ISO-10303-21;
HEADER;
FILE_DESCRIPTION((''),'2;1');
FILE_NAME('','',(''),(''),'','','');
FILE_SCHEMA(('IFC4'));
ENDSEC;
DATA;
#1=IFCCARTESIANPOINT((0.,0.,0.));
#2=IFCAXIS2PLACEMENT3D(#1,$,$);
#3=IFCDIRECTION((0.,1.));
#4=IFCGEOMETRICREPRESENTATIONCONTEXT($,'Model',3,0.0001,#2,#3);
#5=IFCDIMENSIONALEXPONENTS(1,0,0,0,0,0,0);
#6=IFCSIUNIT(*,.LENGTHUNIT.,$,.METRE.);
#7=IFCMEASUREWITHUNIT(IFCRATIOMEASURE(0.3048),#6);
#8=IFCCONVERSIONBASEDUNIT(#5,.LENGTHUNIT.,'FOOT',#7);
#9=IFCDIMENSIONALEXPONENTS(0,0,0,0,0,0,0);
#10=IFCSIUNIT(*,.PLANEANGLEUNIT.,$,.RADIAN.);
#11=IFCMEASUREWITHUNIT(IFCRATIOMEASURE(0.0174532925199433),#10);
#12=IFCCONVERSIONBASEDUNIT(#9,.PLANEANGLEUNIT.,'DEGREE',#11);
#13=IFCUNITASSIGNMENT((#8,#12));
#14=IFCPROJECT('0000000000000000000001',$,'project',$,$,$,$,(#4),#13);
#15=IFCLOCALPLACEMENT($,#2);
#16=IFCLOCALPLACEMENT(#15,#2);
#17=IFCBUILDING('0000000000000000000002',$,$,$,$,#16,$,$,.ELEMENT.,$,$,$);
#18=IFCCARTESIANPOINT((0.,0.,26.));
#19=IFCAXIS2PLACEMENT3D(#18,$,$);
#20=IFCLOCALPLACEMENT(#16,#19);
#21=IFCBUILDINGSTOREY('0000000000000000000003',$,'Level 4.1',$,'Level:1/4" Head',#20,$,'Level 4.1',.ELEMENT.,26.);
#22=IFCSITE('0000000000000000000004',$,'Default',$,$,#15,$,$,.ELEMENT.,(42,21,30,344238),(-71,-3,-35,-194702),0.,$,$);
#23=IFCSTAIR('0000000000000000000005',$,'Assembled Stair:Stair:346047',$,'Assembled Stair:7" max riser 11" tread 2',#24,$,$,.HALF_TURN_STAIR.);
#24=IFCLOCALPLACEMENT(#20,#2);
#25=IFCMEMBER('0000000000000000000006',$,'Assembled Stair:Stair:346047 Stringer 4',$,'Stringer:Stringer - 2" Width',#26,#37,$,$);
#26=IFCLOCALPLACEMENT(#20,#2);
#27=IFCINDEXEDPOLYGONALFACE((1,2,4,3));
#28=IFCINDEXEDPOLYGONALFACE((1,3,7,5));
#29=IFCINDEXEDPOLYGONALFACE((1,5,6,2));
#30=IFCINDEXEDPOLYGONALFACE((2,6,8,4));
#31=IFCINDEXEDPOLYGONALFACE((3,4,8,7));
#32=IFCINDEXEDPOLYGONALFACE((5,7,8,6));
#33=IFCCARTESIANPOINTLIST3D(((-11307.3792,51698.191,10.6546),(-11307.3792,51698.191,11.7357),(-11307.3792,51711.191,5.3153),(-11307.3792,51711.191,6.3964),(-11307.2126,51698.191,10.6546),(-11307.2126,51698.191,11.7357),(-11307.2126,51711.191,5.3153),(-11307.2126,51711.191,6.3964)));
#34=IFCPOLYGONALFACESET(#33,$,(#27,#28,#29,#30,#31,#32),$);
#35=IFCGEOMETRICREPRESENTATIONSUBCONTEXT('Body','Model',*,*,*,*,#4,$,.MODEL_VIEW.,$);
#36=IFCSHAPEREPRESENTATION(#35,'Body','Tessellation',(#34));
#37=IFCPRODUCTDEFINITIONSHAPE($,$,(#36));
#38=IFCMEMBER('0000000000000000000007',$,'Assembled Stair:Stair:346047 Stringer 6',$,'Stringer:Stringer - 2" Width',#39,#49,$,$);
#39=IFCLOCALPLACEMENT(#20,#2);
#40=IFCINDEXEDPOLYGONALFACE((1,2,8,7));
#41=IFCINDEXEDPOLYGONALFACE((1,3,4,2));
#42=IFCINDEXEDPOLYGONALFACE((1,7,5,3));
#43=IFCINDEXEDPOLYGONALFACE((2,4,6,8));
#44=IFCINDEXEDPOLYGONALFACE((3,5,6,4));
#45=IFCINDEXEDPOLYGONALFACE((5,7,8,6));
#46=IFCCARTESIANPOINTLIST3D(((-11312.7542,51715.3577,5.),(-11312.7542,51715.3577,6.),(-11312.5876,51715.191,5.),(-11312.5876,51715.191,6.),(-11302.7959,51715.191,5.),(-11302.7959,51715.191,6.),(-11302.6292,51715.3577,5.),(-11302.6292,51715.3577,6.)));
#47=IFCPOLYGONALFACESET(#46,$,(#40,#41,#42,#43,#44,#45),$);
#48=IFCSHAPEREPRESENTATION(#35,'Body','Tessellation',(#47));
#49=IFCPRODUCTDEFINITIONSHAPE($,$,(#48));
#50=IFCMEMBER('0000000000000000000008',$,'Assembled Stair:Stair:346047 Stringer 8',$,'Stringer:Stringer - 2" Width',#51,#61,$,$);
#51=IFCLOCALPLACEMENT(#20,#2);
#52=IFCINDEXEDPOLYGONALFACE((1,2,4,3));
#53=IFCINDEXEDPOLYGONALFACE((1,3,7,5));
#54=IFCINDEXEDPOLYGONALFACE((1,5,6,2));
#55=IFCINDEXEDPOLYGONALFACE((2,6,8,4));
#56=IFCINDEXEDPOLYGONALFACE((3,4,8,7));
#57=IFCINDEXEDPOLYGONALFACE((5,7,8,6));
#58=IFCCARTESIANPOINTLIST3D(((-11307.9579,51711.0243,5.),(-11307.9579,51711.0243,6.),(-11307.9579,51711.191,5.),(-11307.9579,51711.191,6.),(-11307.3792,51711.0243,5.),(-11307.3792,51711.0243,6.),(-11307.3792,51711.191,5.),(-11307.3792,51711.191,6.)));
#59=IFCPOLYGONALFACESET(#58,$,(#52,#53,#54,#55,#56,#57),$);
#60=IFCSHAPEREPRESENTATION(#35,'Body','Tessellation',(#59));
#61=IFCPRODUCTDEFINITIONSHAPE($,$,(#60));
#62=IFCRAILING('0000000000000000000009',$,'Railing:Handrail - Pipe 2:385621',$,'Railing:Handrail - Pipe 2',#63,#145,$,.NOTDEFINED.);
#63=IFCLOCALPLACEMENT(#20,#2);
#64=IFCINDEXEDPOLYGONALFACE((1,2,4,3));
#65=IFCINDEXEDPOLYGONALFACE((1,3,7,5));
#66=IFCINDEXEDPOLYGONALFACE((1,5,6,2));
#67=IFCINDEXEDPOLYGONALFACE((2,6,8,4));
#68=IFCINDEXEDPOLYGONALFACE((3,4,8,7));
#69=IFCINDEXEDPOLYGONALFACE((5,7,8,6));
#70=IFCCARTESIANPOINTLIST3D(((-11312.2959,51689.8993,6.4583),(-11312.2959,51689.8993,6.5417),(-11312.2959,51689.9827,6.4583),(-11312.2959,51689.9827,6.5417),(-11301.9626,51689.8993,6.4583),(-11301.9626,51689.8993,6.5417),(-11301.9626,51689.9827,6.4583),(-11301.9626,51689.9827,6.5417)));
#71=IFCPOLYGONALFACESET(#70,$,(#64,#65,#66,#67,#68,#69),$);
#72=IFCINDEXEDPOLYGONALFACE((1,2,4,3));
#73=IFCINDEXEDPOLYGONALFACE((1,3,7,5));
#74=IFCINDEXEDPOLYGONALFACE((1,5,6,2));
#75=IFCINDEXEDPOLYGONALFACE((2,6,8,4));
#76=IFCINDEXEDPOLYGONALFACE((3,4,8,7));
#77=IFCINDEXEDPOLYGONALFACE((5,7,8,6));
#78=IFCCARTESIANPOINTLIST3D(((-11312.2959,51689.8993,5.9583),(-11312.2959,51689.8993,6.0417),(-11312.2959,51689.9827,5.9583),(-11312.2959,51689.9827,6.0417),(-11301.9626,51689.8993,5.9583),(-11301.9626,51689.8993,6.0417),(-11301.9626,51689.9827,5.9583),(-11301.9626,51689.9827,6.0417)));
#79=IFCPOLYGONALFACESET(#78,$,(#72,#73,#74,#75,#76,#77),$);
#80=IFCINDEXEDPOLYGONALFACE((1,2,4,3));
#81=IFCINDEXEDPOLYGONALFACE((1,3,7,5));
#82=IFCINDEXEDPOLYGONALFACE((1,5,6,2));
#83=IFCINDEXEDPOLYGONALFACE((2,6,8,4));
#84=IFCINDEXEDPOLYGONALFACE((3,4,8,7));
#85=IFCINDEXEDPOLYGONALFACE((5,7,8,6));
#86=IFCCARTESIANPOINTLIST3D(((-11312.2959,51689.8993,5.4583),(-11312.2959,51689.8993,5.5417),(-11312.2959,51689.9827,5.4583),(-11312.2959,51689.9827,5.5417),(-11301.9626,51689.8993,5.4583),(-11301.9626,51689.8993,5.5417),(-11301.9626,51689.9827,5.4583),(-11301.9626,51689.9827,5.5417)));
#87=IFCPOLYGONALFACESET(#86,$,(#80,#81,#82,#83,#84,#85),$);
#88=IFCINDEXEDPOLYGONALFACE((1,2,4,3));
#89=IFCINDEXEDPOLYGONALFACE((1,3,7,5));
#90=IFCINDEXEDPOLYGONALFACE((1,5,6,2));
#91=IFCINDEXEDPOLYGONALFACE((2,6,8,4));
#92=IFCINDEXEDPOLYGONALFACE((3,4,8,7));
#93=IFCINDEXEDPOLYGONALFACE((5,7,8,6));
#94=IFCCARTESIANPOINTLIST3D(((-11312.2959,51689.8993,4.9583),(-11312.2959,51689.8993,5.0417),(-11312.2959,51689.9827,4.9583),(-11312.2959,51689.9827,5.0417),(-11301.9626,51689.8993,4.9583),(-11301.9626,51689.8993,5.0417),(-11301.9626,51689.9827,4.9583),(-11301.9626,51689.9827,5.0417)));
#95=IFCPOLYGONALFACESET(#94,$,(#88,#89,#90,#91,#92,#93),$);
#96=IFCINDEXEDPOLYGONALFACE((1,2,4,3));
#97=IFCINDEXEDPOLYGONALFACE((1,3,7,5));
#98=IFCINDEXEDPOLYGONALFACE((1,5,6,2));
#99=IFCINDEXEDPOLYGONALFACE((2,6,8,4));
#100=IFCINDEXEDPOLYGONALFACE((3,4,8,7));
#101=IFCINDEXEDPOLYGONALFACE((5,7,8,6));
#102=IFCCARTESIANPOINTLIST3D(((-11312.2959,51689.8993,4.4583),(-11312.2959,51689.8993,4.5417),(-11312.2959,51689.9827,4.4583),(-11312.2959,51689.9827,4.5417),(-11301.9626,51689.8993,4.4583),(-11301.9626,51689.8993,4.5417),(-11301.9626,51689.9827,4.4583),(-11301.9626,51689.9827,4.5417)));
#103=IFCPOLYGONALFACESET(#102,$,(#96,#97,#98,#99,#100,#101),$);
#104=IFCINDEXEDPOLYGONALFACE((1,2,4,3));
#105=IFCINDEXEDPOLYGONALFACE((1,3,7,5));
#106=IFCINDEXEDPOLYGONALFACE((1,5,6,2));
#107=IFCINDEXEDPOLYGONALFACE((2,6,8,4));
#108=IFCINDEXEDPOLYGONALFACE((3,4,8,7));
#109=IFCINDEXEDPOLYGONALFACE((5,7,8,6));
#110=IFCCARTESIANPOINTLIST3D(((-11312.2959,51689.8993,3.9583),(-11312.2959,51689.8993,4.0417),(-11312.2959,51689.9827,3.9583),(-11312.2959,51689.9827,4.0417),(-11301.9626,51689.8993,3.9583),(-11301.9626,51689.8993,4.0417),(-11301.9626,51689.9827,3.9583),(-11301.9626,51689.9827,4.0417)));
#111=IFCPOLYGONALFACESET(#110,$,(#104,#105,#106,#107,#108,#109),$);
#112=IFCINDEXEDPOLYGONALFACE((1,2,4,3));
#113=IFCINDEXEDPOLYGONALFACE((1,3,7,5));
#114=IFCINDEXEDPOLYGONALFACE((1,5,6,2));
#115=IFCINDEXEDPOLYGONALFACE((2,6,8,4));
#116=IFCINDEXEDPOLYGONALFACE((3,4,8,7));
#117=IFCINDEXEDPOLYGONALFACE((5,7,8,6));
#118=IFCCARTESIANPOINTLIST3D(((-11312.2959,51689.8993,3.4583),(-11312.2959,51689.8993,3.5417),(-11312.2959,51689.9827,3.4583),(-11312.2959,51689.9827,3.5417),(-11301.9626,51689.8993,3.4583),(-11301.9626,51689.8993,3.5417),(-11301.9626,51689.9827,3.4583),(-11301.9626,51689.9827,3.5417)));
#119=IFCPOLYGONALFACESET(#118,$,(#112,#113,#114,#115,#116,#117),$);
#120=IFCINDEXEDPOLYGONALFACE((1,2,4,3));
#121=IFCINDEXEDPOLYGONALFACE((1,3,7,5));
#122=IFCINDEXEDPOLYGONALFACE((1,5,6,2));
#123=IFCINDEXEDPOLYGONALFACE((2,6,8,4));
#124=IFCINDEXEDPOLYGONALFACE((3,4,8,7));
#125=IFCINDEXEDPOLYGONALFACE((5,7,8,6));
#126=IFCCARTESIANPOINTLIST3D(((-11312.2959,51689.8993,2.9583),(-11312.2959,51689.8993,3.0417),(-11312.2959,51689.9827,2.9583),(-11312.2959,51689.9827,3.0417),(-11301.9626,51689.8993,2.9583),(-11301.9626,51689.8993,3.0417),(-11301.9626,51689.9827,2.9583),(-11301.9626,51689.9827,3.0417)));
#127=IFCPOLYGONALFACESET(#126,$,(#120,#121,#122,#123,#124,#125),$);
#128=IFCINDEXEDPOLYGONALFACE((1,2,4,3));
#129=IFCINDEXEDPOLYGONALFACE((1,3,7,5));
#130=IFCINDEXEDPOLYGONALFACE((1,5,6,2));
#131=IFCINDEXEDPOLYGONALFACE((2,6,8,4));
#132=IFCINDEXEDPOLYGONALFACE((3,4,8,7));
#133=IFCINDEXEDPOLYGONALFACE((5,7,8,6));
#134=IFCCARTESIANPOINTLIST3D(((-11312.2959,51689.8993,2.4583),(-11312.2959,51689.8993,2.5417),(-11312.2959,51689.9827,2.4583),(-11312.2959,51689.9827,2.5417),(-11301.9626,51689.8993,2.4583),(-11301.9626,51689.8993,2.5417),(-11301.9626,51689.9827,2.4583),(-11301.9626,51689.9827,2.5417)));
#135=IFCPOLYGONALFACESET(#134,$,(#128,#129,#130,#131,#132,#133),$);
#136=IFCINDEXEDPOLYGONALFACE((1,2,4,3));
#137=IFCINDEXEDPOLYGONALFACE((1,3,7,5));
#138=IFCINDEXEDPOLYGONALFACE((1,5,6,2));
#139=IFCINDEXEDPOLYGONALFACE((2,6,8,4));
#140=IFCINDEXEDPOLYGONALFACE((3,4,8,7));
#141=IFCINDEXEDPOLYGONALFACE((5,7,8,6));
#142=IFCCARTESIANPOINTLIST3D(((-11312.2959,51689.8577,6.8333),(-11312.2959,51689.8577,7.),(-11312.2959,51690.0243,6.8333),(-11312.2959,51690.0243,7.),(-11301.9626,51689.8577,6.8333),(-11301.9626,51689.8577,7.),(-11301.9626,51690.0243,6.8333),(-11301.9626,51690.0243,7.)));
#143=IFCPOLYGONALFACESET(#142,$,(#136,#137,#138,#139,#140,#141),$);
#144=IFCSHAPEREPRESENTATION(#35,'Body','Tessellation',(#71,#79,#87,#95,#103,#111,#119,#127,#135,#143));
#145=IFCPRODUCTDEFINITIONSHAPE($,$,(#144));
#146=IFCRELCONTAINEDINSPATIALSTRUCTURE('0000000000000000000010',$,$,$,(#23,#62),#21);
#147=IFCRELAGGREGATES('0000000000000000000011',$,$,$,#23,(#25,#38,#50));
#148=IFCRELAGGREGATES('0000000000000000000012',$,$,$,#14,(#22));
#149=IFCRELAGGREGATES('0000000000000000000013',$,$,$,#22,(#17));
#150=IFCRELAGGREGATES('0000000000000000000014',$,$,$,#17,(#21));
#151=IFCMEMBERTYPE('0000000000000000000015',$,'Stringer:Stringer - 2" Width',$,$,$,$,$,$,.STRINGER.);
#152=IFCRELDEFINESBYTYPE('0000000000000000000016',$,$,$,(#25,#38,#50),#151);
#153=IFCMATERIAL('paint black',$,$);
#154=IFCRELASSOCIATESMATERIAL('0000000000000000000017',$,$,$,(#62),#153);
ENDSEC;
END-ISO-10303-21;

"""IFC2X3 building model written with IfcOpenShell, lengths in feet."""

from ifc_helpers import new_model, entity, si_unit, converted_unit, direction, frame, frame_2d, origin, place, context, subcontext, project, spatial, polyline, rectangle, outline, extrude, material, type_object, element, aggregate, save


model = new_model("IFC2X3")

# Units and contexts
model_context = context("Model", 3, precision=0.0001, world=origin(), true_north=direction((0.0, 1.0)))
body_context = subcontext(model_context, "Body", "Model", "MODEL_VIEW")
ifc_project = project(units=[converted_unit("LENGTHUNIT", "FOOT", entity("IfcRatioMeasure", 0.3048), si_unit("LENGTHUNIT", "METRE"), dimensions=[1, 0, 0, 0, 0, 0, 0]), converted_unit("PLANEANGLEUNIT", "DEGREE", entity("IfcRatioMeasure", 0.0174532925199433), si_unit("PLANEANGLEUNIT", "RADIAN"), dimensions=[0, 0, 0, 0, 0, 0, 0])], contexts=[model_context])

# Site, building, storey
site_placement = place(None, origin())
site = spatial("IfcSite", under=ifc_project, at=site_placement, Name="Default", CompositionType="ELEMENT", RefLatitude=(42, 21, 30, 344238), RefLongitude=(-71, -3, -35, -194702), RefElevation=0.0)
building_placement = place(site_placement, origin())
building = spatial("IfcBuilding", under=site, at=building_placement, CompositionType="ELEMENT")
storey_placement = place(building_placement, frame((0.0, 0.0, 26.0)))
storey = spatial("IfcBuildingStorey", under=building, at=storey_placement, Name="Level 4.1", ObjectType="Level:1/4\" Head", LongName="Level 4.1", CompositionType="ELEMENT", Elevation=26.0)

# Stair, members
stair_placement = place(storey_placement, origin())
stair = element("IfcStair", 1, at=stair_placement, inside=storey, Name="Assembled Stair:Stair:346047", ObjectType="Assembled Stair:7\" max riser 11\" tread 2", ShapeType="HALF_TURN_STAIR")
member_type = type_object("IfcMemberType", Name="Stringer:Stringer - 2\" Width", PredefinedType="STRINGER")
member_1_placement = place(stair_placement, origin())
member_1 = element("IfcMember", 2, at=member_1_placement, type_object=member_type, Name="Assembled Stair:Stair:346047 Stringer 4", ObjectType="Stringer:Stringer - 2\" Width", context=body_context, shape_type="SweptSolid", body=[
    extrude(outline(polyline([(-6.8215, -0.5), (7.2322, -0.5), (6.8215, 0.5), (-7.2322, 0.5), (-6.8215, -0.5)])), frame((-11307.3792, 51704.691, 8.5255), z_axis=(1.0, 0.0, 0.0), x_axis=(0.0, -0.92502, 0.379919)), (0.0, 0.0, 1.0), 0.1667),
])
member_2_placement = place(stair_placement, origin())
member_2 = element("IfcMember", 3, at=member_2_placement, type_object=member_type, Name="Assembled Stair:Stair:346047 Stringer 6", ObjectType="Stringer:Stringer - 2\" Width", context=body_context, shape_type="SweptSolid", body=[
    extrude(outline(polyline([(-5.0625, -0.0833), (5.0625, -0.0833), (4.8958, 0.0833), (-4.8958, 0.0833), (-5.0625, -0.0833)])), frame((-11307.6917, 51715.2743, 5.0), z_axis=(0.0, 0.0, 1.0), x_axis=(-1.0, 0.0, 0.0)), (0.0, 0.0, 1.0), 1.0),
])
member_3_placement = place(stair_placement, origin())
member_3 = element("IfcMember", 4, at=member_3_placement, type_object=member_type, Name="Assembled Stair:Stair:346047 Stringer 8", ObjectType="Stringer:Stringer - 2\" Width", context=body_context, shape_type="SweptSolid", body=[
    extrude(rectangle(XDim=0.5786, YDim=0.1667, at=frame_2d((0.0, 0.0), x_axis=(1.0, 0.0))), frame((-11307.6686, 51711.1077, 5.0)), (0.0, 0.0, 1.0), 1.0),
])
aggregate(stair, [member_1, member_2, member_3])

# Railing
ifc_material_1 = material(Name="paint black")
railing_1_placement = place(storey_placement, origin())
element("IfcRailing", 5, at=railing_1_placement, inside=storey, material=ifc_material_1, Name="Railing:Handrail - Pipe 2:385621", ObjectType="Railing:Handrail - Pipe 2", PredefinedType="NOTDEFINED", context=body_context, shape_type="SweptSolid", body=[
    extrude(rectangle(XDim=10.3333, YDim=0.0833, at=frame_2d((0.0, 0.0), x_axis=(1.0, 0.0))), frame((-11307.1292, 51689.941, 6.4583), z_axis=(0.0, 0.0, 1.0), x_axis=(-1.0, 0.0, 0.0)), (0.0, 0.0, 1.0), 0.0833),
    extrude(rectangle(XDim=10.3333, YDim=0.0833, at=frame_2d((0.0, 0.0), x_axis=(1.0, 0.0))), frame((-11307.1292, 51689.941, 5.9583), z_axis=(0.0, 0.0, 1.0), x_axis=(-1.0, 0.0, 0.0)), (0.0, 0.0, 1.0), 0.0833),
    extrude(rectangle(XDim=10.3333, YDim=0.0833, at=frame_2d((0.0, 0.0), x_axis=(1.0, 0.0))), frame((-11307.1292, 51689.941, 5.4583), z_axis=(0.0, 0.0, 1.0), x_axis=(-1.0, 0.0, 0.0)), (0.0, 0.0, 1.0), 0.0833),
    extrude(rectangle(XDim=10.3333, YDim=0.0833, at=frame_2d((0.0, 0.0), x_axis=(1.0, 0.0))), frame((-11307.1292, 51689.941, 4.9583), z_axis=(0.0, 0.0, 1.0), x_axis=(-1.0, 0.0, 0.0)), (0.0, 0.0, 1.0), 0.0833),
    extrude(rectangle(XDim=10.3333, YDim=0.0833, at=frame_2d((0.0, 0.0), x_axis=(1.0, 0.0))), frame((-11307.1292, 51689.941, 4.4583), z_axis=(0.0, 0.0, 1.0), x_axis=(-1.0, 0.0, 0.0)), (0.0, 0.0, 1.0), 0.0833),
    extrude(rectangle(XDim=10.3333, YDim=0.0833, at=frame_2d((0.0, 0.0), x_axis=(1.0, 0.0))), frame((-11307.1292, 51689.941, 3.9583), z_axis=(0.0, 0.0, 1.0), x_axis=(-1.0, 0.0, 0.0)), (0.0, 0.0, 1.0), 0.0833),
    extrude(rectangle(XDim=10.3333, YDim=0.0833, at=frame_2d((0.0, 0.0), x_axis=(1.0, 0.0))), frame((-11307.1292, 51689.941, 3.4583), z_axis=(0.0, 0.0, 1.0), x_axis=(-1.0, 0.0, 0.0)), (0.0, 0.0, 1.0), 0.0833),
    extrude(rectangle(XDim=10.3333, YDim=0.0833, at=frame_2d((0.0, 0.0), x_axis=(1.0, 0.0))), frame((-11307.1292, 51689.941, 2.9583), z_axis=(0.0, 0.0, 1.0), x_axis=(-1.0, 0.0, 0.0)), (0.0, 0.0, 1.0), 0.0833),
    extrude(rectangle(XDim=10.3333, YDim=0.0833, at=frame_2d((0.0, 0.0), x_axis=(1.0, 0.0))), frame((-11307.1292, 51689.941, 2.4583), z_axis=(0.0, 0.0, 1.0), x_axis=(-1.0, 0.0, 0.0)), (0.0, 0.0, 1.0), 0.0833),
    extrude(rectangle(XDim=10.3333, YDim=0.1667, at=frame_2d((0.0, 0.0), x_axis=(1.0, 0.0))), frame((-11307.1292, 51689.941, 6.8333), z_axis=(0.0, 0.0, 1.0), x_axis=(-1.0, 0.0, 0.0)), (0.0, 0.0, 1.0), 0.1667),
])

save(model, "model.ifc")
